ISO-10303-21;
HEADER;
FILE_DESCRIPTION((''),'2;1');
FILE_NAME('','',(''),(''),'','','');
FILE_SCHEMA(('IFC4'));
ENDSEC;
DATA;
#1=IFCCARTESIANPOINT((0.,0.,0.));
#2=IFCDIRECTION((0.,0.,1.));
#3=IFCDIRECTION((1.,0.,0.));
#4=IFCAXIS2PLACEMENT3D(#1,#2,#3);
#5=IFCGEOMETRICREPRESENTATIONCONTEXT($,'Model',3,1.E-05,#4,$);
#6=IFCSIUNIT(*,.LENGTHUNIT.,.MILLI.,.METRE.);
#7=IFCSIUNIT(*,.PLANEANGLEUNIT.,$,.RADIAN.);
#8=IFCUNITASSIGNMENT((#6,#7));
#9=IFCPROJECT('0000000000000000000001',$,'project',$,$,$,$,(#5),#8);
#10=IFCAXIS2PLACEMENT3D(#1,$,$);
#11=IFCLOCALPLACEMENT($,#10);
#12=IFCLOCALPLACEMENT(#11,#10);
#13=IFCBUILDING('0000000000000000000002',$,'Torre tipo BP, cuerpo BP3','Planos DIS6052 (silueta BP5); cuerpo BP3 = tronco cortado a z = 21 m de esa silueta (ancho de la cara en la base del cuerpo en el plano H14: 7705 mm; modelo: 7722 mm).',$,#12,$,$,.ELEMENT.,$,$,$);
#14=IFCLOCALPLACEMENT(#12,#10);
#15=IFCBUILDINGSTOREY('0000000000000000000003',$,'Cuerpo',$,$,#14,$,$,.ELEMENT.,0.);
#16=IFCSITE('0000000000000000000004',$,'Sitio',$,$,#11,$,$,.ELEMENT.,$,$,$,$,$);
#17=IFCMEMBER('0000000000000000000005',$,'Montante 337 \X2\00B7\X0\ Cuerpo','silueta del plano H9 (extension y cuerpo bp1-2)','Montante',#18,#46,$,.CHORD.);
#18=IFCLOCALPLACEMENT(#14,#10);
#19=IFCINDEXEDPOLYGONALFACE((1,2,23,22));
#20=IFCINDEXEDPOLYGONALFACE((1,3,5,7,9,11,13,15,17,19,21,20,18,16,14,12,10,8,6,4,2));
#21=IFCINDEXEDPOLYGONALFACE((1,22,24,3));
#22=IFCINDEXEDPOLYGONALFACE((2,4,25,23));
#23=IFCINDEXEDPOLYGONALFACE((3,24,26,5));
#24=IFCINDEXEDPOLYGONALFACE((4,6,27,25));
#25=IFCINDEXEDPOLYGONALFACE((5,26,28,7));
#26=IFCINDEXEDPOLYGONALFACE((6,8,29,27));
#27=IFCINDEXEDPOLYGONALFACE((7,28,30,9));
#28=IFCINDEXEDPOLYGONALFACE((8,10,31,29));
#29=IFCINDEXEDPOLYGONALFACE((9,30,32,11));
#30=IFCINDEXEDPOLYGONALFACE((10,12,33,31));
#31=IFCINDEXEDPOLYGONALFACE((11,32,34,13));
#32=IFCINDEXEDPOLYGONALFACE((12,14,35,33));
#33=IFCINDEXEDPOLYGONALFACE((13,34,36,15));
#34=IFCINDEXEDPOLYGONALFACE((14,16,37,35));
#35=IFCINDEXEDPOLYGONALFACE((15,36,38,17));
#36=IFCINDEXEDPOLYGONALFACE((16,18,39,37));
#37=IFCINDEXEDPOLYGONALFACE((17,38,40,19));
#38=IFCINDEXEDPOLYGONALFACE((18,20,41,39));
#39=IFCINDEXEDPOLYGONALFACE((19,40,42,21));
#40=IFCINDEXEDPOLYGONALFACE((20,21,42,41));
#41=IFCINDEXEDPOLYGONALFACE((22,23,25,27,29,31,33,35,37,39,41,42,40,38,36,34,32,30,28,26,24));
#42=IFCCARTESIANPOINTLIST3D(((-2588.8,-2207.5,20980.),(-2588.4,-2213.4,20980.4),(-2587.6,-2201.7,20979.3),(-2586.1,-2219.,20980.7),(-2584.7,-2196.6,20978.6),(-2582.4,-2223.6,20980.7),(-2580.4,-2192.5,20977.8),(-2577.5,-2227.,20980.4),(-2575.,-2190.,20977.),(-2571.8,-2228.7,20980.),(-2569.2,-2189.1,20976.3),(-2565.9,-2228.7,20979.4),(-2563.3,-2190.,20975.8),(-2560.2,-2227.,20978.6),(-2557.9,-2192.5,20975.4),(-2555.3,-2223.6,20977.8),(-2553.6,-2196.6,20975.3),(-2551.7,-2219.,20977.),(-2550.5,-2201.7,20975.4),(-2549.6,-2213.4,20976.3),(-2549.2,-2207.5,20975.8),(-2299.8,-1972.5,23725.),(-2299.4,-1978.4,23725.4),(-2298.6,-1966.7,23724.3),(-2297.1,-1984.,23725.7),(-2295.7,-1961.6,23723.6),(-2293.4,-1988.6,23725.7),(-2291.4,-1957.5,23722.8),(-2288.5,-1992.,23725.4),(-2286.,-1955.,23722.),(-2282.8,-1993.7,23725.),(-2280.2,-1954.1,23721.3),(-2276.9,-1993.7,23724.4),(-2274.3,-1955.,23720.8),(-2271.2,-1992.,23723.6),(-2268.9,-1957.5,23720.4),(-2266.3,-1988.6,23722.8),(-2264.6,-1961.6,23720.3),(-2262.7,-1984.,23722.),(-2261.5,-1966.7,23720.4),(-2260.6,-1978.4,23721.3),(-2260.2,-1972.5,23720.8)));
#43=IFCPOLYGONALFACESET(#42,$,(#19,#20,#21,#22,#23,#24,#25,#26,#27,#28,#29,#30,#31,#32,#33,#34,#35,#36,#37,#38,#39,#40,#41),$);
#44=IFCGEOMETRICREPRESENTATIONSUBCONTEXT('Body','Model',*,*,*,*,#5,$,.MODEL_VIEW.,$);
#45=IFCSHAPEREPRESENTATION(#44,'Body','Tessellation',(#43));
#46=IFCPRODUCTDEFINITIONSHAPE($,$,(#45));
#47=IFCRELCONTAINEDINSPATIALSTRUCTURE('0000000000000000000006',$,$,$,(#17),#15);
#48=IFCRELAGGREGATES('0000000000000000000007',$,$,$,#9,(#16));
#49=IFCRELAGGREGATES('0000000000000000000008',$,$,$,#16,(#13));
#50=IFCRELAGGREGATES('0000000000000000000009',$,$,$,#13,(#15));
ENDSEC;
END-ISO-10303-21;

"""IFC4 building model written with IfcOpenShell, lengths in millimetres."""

from ifc_helpers import new_model, si_unit, frame, origin, origin_with_axes, place, context, subcontext, project, spatial, circle, extrude, element, save


model = new_model("IFC4")

# Units and contexts
model_context = context("Model", 3, precision=1e-05, world=origin_with_axes())
body_context = subcontext(model_context, "Body", "Model", "MODEL_VIEW")
ifc_project = project(units=[si_unit("LENGTHUNIT", "METRE", prefix="MILLI"), si_unit("PLANEANGLEUNIT", "RADIAN")], contexts=[model_context])

# Site, building, storey
site_placement = place(None, origin())
site = spatial("IfcSite", under=ifc_project, at=site_placement, Name="Sitio", CompositionType="ELEMENT")
building_placement = place(site_placement, origin())
building = spatial("IfcBuilding", under=site, at=building_placement, Name="Torre tipo BP, cuerpo BP3", Description="Planos DIS6052 (silueta BP5); cuerpo BP3 = tronco cortado a z = 21 m de esa silueta (ancho de la cara en la base del cuerpo en el plano H14: 7705 mm; modelo: 7722 mm).", CompositionType="ELEMENT")
storey_placement = place(building_placement, origin())
storey = spatial("IfcBuildingStorey", under=building, at=storey_placement, Name="Cuerpo", CompositionType="ELEMENT", Elevation=0.0)

# Member
member_1_placement = place(storey_placement, frame((-2280.0, -1974.0, 23723.0), z_axis=(-0.104326, -0.084833, -0.990918), x_axis=(-0.008882, 0.996395, -0.084366)))
element("IfcMember", 1, at=member_1_placement, inside=storey, Name="Montante 337 · Cuerpo", Description="silueta del plano H9 (extension y cuerpo bp1-2)", ObjectType="Montante", PredefinedType="CHORD", context=body_context, shape_type="SweptSolid", body=[
    extrude(circle(Radius=20.0), None, (0.0, 0.0, 1.0), 2770.2),
])

save(model, "model.ifc")
